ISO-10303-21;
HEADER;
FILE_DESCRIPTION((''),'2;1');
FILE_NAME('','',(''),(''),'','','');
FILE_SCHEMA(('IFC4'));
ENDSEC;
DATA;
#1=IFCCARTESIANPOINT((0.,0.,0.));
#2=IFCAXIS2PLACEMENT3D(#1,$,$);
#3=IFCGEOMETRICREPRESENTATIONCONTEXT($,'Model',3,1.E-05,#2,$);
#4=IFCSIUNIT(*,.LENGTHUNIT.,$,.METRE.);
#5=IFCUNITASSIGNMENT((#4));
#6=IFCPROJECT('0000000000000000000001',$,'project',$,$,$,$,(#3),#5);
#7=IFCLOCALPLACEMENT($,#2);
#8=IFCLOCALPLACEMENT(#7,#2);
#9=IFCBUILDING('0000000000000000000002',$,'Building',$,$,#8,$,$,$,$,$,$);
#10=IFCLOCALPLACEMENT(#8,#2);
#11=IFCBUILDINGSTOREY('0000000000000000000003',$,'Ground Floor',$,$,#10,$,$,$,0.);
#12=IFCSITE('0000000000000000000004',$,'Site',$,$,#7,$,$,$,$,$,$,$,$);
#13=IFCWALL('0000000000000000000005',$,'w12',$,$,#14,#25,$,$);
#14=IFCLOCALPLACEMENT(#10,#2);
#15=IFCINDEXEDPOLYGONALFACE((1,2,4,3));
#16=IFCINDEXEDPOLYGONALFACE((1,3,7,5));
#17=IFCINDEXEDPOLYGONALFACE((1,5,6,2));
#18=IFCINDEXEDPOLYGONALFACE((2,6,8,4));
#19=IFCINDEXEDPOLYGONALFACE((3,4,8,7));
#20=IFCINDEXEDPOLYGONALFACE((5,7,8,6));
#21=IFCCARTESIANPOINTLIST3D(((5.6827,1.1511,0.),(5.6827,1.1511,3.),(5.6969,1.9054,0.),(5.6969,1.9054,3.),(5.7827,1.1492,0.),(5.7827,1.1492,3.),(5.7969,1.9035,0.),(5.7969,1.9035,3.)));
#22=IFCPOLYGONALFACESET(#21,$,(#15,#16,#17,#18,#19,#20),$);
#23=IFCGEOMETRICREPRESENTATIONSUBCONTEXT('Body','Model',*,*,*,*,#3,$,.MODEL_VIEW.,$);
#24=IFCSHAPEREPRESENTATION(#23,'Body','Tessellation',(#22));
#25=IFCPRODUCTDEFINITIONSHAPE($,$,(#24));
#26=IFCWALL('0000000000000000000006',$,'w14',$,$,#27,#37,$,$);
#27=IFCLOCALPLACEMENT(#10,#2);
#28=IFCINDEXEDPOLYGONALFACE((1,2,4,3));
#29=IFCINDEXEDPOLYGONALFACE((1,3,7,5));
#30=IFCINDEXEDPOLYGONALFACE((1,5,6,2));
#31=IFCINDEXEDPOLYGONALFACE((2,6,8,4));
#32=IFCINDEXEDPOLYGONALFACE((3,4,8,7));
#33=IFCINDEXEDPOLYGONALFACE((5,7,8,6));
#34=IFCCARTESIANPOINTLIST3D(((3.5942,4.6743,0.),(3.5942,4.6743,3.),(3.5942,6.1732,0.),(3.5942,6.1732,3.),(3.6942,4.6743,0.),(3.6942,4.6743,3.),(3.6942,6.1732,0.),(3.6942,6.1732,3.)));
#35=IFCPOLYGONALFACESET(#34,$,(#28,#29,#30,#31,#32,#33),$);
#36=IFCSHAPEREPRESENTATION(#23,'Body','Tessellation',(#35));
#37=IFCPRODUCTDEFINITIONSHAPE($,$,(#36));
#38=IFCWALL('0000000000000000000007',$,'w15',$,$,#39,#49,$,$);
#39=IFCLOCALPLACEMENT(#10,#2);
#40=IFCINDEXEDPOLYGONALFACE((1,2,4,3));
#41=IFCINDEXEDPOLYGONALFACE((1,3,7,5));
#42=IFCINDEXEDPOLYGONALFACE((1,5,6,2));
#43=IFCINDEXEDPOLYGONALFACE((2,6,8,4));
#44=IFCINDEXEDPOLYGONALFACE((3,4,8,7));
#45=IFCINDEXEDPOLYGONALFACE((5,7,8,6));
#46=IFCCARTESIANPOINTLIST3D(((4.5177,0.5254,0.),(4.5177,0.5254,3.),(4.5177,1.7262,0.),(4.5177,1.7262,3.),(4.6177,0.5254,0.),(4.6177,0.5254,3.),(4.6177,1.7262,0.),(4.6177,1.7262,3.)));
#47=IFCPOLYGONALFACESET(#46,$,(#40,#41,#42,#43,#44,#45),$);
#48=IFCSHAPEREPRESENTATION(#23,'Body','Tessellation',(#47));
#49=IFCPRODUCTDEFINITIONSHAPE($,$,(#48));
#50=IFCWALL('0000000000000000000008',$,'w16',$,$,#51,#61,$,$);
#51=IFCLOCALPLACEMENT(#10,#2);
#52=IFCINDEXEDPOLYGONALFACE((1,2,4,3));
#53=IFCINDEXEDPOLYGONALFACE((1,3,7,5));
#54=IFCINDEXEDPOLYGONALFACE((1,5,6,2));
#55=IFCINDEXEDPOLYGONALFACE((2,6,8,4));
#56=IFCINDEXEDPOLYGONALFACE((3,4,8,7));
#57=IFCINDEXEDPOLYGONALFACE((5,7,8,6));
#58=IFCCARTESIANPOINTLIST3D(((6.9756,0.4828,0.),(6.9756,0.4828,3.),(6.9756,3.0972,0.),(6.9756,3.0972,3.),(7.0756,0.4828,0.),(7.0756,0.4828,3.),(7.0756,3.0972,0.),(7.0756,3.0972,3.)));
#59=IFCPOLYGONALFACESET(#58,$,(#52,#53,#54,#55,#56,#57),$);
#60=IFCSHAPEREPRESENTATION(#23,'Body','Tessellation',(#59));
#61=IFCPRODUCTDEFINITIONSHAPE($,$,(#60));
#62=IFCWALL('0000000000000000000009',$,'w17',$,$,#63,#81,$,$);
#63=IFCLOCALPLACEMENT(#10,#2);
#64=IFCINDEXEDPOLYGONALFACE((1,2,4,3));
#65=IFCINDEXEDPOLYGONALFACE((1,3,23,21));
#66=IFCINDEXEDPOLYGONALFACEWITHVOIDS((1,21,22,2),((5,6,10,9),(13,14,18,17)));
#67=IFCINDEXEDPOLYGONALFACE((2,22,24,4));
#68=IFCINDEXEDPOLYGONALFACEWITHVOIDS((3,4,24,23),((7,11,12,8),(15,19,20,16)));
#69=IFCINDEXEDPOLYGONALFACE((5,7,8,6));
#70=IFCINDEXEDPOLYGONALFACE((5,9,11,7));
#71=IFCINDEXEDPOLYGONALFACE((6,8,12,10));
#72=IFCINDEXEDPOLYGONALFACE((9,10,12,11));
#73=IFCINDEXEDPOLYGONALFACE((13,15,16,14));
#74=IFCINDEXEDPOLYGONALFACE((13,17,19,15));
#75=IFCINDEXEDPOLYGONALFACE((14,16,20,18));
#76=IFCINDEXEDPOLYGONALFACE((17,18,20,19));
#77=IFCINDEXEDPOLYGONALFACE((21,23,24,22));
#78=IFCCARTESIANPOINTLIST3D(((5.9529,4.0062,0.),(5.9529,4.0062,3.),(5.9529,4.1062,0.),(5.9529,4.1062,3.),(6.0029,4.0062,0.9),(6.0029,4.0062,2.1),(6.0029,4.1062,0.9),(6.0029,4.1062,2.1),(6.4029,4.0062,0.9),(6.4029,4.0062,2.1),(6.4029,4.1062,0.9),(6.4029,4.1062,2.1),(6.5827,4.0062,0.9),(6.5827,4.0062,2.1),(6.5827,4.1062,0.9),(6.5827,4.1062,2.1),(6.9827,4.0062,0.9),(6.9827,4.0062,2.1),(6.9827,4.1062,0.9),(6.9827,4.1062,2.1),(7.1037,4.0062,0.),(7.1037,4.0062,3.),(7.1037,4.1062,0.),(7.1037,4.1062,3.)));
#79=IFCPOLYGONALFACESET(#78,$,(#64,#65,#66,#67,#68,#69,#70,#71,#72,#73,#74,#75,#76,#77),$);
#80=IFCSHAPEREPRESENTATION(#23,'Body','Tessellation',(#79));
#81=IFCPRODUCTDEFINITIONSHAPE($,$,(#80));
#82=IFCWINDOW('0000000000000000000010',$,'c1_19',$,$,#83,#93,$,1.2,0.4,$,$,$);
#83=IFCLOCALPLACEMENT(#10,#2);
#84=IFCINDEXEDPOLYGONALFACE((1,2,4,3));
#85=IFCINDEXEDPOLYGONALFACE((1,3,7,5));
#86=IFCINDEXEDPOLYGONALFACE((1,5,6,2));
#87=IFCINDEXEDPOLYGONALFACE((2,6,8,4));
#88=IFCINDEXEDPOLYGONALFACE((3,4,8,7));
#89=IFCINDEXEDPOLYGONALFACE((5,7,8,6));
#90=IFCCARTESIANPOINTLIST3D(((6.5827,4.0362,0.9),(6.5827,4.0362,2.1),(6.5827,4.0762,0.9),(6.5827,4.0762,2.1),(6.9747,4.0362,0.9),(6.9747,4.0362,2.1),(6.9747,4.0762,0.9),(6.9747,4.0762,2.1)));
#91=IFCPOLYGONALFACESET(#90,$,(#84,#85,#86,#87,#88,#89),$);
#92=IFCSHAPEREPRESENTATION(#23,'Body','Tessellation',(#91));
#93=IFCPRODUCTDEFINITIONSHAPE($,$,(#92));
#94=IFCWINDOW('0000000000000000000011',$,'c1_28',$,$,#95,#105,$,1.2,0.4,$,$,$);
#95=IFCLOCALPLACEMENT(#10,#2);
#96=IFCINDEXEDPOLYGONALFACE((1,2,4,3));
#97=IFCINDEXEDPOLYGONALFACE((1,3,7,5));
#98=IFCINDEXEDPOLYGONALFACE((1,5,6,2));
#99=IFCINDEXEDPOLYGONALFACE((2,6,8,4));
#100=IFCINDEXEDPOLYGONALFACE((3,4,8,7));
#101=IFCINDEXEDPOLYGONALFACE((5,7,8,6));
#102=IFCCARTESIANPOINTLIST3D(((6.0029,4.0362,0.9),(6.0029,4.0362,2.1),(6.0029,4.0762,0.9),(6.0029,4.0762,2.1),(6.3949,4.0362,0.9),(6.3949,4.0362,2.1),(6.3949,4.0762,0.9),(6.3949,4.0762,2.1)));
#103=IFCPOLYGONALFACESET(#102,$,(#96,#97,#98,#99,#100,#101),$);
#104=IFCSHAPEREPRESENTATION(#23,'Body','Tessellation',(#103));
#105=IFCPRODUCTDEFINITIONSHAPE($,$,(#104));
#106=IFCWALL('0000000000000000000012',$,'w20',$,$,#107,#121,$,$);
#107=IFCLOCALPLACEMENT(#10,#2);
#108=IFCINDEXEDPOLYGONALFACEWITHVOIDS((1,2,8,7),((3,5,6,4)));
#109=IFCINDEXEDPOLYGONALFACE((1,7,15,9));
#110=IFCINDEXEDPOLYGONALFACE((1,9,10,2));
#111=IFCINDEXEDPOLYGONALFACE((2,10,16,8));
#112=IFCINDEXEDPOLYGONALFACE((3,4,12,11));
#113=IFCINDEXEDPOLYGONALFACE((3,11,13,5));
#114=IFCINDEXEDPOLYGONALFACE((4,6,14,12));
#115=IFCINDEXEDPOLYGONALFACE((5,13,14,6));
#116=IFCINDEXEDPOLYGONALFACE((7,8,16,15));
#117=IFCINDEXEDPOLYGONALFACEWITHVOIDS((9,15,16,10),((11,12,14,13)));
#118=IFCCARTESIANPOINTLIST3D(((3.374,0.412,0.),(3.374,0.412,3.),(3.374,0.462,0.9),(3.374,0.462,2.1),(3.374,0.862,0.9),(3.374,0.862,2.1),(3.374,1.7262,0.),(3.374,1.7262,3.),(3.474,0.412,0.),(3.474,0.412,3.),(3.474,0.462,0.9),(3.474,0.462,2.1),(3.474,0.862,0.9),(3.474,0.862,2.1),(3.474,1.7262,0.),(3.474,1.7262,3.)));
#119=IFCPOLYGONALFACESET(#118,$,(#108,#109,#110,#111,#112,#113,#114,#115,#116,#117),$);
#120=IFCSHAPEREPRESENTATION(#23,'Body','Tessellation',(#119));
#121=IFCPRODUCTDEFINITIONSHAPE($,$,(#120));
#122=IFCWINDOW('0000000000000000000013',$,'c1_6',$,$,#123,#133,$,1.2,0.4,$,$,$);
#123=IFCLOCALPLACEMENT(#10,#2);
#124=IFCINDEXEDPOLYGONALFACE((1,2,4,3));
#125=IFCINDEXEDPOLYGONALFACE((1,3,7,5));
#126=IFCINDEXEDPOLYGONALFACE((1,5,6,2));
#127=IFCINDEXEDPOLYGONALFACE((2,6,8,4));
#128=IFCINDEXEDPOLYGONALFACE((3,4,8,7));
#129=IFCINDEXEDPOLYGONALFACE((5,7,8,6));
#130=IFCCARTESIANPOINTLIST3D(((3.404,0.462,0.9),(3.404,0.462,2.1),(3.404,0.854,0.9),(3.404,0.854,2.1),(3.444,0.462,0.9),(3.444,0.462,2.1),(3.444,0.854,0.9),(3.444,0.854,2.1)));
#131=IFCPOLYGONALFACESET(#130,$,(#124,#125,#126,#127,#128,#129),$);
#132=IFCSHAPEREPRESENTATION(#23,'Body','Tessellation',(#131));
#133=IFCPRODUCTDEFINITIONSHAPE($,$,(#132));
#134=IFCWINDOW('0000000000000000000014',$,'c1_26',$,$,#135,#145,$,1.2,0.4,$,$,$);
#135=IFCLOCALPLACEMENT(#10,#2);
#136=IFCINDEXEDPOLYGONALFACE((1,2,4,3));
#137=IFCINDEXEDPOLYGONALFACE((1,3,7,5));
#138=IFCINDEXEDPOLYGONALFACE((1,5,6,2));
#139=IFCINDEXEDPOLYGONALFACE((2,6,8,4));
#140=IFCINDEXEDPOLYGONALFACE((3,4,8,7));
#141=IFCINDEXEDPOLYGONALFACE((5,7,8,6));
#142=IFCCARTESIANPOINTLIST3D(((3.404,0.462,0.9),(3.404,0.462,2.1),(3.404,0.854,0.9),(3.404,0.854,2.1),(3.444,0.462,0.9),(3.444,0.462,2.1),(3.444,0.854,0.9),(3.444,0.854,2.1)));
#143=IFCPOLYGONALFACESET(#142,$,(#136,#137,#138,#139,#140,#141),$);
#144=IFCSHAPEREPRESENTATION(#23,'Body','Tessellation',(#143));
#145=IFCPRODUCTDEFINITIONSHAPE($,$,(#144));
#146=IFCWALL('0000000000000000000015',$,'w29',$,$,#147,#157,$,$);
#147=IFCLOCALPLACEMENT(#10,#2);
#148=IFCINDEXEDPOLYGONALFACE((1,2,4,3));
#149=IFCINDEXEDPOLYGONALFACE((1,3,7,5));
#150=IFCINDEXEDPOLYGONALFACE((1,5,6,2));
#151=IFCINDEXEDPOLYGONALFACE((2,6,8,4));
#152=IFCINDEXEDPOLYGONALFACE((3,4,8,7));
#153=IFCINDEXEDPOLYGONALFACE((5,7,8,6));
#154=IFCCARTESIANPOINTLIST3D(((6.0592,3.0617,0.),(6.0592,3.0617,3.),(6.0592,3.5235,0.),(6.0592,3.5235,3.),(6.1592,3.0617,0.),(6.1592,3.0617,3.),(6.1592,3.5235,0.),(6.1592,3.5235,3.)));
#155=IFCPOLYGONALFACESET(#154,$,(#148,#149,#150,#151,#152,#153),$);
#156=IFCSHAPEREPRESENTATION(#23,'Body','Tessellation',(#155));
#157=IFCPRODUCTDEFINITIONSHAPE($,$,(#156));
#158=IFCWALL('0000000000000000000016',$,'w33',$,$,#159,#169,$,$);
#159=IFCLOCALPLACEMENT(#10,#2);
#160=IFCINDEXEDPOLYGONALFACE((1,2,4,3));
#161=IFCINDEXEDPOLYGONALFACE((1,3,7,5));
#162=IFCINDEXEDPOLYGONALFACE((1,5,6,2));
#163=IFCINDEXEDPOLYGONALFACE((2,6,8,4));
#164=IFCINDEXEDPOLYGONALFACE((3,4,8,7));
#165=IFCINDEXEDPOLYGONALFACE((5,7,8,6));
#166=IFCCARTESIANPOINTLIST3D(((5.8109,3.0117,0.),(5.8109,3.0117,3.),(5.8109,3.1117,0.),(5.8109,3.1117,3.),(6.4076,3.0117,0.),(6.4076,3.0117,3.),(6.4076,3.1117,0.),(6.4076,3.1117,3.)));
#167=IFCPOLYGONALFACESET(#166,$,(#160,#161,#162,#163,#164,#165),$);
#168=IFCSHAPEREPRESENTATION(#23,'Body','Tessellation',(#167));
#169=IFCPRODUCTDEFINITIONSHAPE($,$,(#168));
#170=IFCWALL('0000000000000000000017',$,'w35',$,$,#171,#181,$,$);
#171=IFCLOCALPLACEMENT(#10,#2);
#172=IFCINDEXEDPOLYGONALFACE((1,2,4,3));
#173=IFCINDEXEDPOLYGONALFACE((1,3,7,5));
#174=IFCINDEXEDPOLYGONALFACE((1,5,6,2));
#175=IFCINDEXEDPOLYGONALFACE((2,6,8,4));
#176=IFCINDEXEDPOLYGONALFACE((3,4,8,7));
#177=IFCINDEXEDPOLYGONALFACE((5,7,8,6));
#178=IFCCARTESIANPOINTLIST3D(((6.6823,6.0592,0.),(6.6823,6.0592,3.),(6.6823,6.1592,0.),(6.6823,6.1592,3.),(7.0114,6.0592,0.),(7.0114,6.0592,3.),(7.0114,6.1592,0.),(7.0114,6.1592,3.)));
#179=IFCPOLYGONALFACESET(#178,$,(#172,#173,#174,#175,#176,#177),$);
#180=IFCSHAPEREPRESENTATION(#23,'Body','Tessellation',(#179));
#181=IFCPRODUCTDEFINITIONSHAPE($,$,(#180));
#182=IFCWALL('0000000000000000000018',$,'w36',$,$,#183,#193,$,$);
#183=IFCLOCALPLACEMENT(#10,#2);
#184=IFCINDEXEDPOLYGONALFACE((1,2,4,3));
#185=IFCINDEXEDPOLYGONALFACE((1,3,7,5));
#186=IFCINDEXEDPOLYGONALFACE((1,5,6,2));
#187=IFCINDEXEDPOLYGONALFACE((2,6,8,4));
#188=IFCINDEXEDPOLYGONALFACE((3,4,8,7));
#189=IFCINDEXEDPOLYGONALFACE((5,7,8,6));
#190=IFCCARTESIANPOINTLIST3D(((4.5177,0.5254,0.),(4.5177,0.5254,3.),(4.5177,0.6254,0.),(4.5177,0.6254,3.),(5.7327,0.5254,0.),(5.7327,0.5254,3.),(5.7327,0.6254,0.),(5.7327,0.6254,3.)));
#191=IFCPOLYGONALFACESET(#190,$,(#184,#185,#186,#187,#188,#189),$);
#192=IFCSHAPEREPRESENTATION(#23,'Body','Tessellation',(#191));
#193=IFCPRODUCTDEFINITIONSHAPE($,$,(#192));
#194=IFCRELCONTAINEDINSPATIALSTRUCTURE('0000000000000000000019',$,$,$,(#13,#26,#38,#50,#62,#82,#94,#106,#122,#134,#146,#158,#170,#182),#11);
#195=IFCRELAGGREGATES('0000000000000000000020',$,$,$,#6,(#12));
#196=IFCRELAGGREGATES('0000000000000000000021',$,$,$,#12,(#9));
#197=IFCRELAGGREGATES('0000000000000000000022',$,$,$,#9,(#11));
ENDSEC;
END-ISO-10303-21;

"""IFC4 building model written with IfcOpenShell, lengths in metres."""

from ifc_helpers import new_model, si_unit, frame, origin, place, context, subcontext, project, spatial, polyline, outline, extrude, element, fill, save


model = new_model("IFC4")

# Units and contexts
model_context = context("Model", 3, precision=1e-05, world=origin())
body_context = subcontext(model_context, "Body", "Model", "MODEL_VIEW")
ifc_project = project(units=[si_unit("LENGTHUNIT", "METRE")], contexts=[model_context])

# Site, building, storey
site_placement = place(None, origin())
site = spatial("IfcSite", under=ifc_project, at=site_placement, Name="Site")
building_placement = place(site_placement, origin())
building = spatial("IfcBuilding", under=site, at=building_placement, Name="Building")
storey_placement = place(building_placement, origin())
storey = spatial("IfcBuildingStorey", under=building, at=storey_placement, Name="Ground Floor", Elevation=0.0)

# Walls
wall_1_placement = place(storey_placement, frame((5.7327, 1.1501, 0.0), x_axis=(0.018855, 0.999822, 0.0)))
element("IfcWall", 1, at=wall_1_placement, inside=storey, Name="w12", context=body_context, shape_type="SweptSolid", body=[
    extrude(outline(polyline([(0.0, -0.05), (0.7545, -0.05), (0.7545, 0.05), (0.0, 0.05), (0.0, -0.05)])), origin(), (0.0, 0.0, 1.0), 3.0),
])
wall_2_placement = place(storey_placement, frame((3.6442, 4.6743, 0.0), x_axis=(0.0, 1.0, 0.0)))
element("IfcWall", 2, at=wall_2_placement, inside=storey, Name="w14", context=body_context, shape_type="SweptSolid", body=[
    extrude(outline(polyline([(0.0, -0.05), (1.4989, -0.05), (1.4989, 0.05), (0.0, 0.05), (0.0, -0.05)])), origin(), (0.0, 0.0, 1.0), 3.0),
])
wall_3_placement = place(storey_placement, frame((4.5677, 0.5754, 0.0), x_axis=(0.0, 1.0, 0.0)))
element("IfcWall", 3, at=wall_3_placement, inside=storey, Name="w15", context=body_context, shape_type="SweptSolid", body=[
    extrude(outline(polyline([(-0.05, -0.05), (1.1508, -0.05), (1.1508, 0.05), (-0.05, 0.05), (-0.05, -0.05)])), origin(), (0.0, 0.0, 1.0), 3.0),
])
wall_4_placement = place(storey_placement, frame((7.0256, 0.5328, 0.0), x_axis=(0.0, 1.0, 0.0)))
element("IfcWall", 4, at=wall_4_placement, inside=storey, Name="w16", context=body_context, shape_type="SweptSolid", body=[
    extrude(outline(polyline([(-0.05, -0.05), (2.5645, -0.05), (2.5645, 0.05), (-0.05, 0.05), (-0.05, -0.05)])), origin(), (0.0, 0.0, 1.0), 3.0),
])

# Walls, openings, windows
wall_5_placement = place(storey_placement, frame((5.9529, 4.0562, 0.0), x_axis=(1.0, 0.0, 0.0)))
wall_5 = element("IfcWall", 5, at=wall_5_placement, inside=storey, Name="w17", context=body_context, shape_type="SweptSolid", body=[
    extrude(outline(polyline([(0.0, -0.05), (1.1508, -0.05), (1.1508, 0.05), (0.0, 0.05), (0.0, -0.05)])), origin(), (0.0, 0.0, 1.0), 3.0),
])
opening_1_placement = place(wall_5_placement, frame((0.6298, 0.0, 0.0)))
opening_1 = element("IfcOpeningElement", 6, at=opening_1_placement, cuts=wall_5, context=body_context, shape_type="SweptSolid", body=[
    extrude(outline(polyline([(0.0, -0.0525), (0.4, -0.0525), (0.4, 0.0525), (0.0, 0.0525), (0.0, -0.0525)])), frame((0.0, 0.0, 0.9)), (0.0, 0.0, 1.0), 1.2),
])
opening_2_placement = place(wall_5_placement, frame((0.05, 0.0, 0.0)))
opening_2 = element("IfcOpeningElement", 7, at=opening_2_placement, cuts=wall_5, context=body_context, shape_type="SweptSolid", body=[
    extrude(outline(polyline([(0.0, -0.0525), (0.4, -0.0525), (0.4, 0.0525), (0.0, 0.0525), (0.0, -0.0525)])), frame((0.0, 0.0, 0.9)), (0.0, 0.0, 1.0), 1.2),
])
window_1_placement = place(wall_5_placement, frame((0.6298, 0.0, 0.0)))
window_1 = element("IfcWindow", 8, at=window_1_placement, inside=storey, Name="c1_19", OverallHeight=1.2, OverallWidth=0.4, context=body_context, shape_type="SweptSolid", body=[
    extrude(outline(polyline([(0.0, -0.02), (0.392, -0.02), (0.392, 0.02), (0.0, 0.02), (0.0, -0.02)])), frame((0.0, 0.0, 0.9)), (0.0, 0.0, 1.0), 1.2),
])
fill(opening_1, window_1)
window_2_placement = place(wall_5_placement, frame((0.05, 0.0, 0.0)))
window_2 = element("IfcWindow", 9, at=window_2_placement, inside=storey, Name="c1_28", OverallHeight=1.2, OverallWidth=0.4, context=body_context, shape_type="SweptSolid", body=[
    extrude(outline(polyline([(0.0, -0.02), (0.392, -0.02), (0.392, 0.02), (0.0, 0.02), (0.0, -0.02)])), frame((0.0, 0.0, 0.9)), (0.0, 0.0, 1.0), 1.2),
])
fill(opening_2, window_2)
wall_6_placement = place(storey_placement, frame((3.424, 0.412, 0.0), x_axis=(0.0, 1.0, 0.0)))
wall_6 = element("IfcWall", 10, at=wall_6_placement, inside=storey, Name="w20", context=body_context, shape_type="SweptSolid", body=[
    extrude(outline(polyline([(0.0, -0.05), (1.3142, -0.05), (1.3142, 0.05), (0.0, 0.05), (0.0, -0.05)])), origin(), (0.0, 0.0, 1.0), 3.0),
])
opening_3_placement = place(wall_6_placement, frame((0.05, 0.0, 0.0)))
opening_3 = element("IfcOpeningElement", 11, at=opening_3_placement, cuts=wall_6, context=body_context, shape_type="SweptSolid", body=[
    extrude(outline(polyline([(0.0, -0.0525), (0.4, -0.0525), (0.4, 0.0525), (0.0, 0.0525), (0.0, -0.0525)])), frame((0.0, 0.0, 0.9)), (0.0, 0.0, 1.0), 1.2),
])
opening_4_placement = place(wall_6_placement, frame((0.05, 0.0, 0.0)))
opening_4 = element("IfcOpeningElement", 12, at=opening_4_placement, cuts=wall_6, context=body_context, shape_type="SweptSolid", body=[
    extrude(outline(polyline([(0.0, -0.0525), (0.4, -0.0525), (0.4, 0.0525), (0.0, 0.0525), (0.0, -0.0525)])), frame((0.0, 0.0, 0.9)), (0.0, 0.0, 1.0), 1.2),
])
window_3_placement = place(wall_6_placement, frame((0.05, 0.0, 0.0)))
window_3 = element("IfcWindow", 13, at=window_3_placement, inside=storey, Name="c1_6", OverallHeight=1.2, OverallWidth=0.4, context=body_context, shape_type="SweptSolid", body=[
    extrude(outline(polyline([(0.0, -0.02), (0.392, -0.02), (0.392, 0.02), (0.0, 0.02), (0.0, -0.02)])), frame((0.0, 0.0, 0.9)), (0.0, 0.0, 1.0), 1.2),
])
fill(opening_3, window_3)
window_4_placement = place(wall_6_placement, frame((0.05, 0.0, 0.0)))
window_4 = element("IfcWindow", 14, at=window_4_placement, inside=storey, Name="c1_26", OverallHeight=1.2, OverallWidth=0.4, context=body_context, shape_type="SweptSolid", body=[
    extrude(outline(polyline([(0.0, -0.02), (0.392, -0.02), (0.392, 0.02), (0.0, 0.02), (0.0, -0.02)])), frame((0.0, 0.0, 0.9)), (0.0, 0.0, 1.0), 1.2),
])
fill(opening_4, window_4)

# Walls
wall_7_placement = place(storey_placement, frame((6.1092, 3.0617, 0.0), x_axis=(0.0, 1.0, 0.0)))
element("IfcWall", 15, at=wall_7_placement, inside=storey, Name="w29", context=body_context, shape_type="SweptSolid", body=[
    extrude(outline(polyline([(0.0, -0.05), (0.4617, -0.05), (0.4617, 0.05), (0.0, 0.05), (0.0, -0.05)])), origin(), (0.0, 0.0, 1.0), 3.0),
])
wall_8_placement = place(storey_placement, frame((5.8109, 3.0617, 0.0), x_axis=(1.0, 0.0, 0.0)))
element("IfcWall", 16, at=wall_8_placement, inside=storey, Name="w33", context=body_context, shape_type="SweptSolid", body=[
    extrude(outline(polyline([(0.0, -0.05), (0.5967, -0.05), (0.5967, 0.05), (0.0, 0.05), (0.0, -0.05)])), origin(), (0.0, 0.0, 1.0), 3.0),
])
wall_9_placement = place(storey_placement, frame((6.6823, 6.1092, 0.0), x_axis=(1.0, 0.0, 0.0)))
element("IfcWall", 17, at=wall_9_placement, inside=storey, Name="w35", context=body_context, shape_type="SweptSolid", body=[
    extrude(outline(polyline([(0.0, -0.05), (0.3291, -0.05), (0.3291, 0.05), (0.0, 0.05), (0.0, -0.05)])), origin(), (0.0, 0.0, 1.0), 3.0),
])
wall_10_placement = place(storey_placement, frame((4.5677, 0.5754, 0.0), x_axis=(1.0, 0.0, 0.0)))
element("IfcWall", 18, at=wall_10_placement, inside=storey, Name="w36", context=body_context, shape_type="SweptSolid", body=[
    extrude(outline(polyline([(-0.05, -0.05), (1.165, -0.05), (1.165, 0.05), (-0.05, 0.05), (-0.05, -0.05)])), origin(), (0.0, 0.0, 1.0), 3.0),
])

save(model, "model.ifc")
